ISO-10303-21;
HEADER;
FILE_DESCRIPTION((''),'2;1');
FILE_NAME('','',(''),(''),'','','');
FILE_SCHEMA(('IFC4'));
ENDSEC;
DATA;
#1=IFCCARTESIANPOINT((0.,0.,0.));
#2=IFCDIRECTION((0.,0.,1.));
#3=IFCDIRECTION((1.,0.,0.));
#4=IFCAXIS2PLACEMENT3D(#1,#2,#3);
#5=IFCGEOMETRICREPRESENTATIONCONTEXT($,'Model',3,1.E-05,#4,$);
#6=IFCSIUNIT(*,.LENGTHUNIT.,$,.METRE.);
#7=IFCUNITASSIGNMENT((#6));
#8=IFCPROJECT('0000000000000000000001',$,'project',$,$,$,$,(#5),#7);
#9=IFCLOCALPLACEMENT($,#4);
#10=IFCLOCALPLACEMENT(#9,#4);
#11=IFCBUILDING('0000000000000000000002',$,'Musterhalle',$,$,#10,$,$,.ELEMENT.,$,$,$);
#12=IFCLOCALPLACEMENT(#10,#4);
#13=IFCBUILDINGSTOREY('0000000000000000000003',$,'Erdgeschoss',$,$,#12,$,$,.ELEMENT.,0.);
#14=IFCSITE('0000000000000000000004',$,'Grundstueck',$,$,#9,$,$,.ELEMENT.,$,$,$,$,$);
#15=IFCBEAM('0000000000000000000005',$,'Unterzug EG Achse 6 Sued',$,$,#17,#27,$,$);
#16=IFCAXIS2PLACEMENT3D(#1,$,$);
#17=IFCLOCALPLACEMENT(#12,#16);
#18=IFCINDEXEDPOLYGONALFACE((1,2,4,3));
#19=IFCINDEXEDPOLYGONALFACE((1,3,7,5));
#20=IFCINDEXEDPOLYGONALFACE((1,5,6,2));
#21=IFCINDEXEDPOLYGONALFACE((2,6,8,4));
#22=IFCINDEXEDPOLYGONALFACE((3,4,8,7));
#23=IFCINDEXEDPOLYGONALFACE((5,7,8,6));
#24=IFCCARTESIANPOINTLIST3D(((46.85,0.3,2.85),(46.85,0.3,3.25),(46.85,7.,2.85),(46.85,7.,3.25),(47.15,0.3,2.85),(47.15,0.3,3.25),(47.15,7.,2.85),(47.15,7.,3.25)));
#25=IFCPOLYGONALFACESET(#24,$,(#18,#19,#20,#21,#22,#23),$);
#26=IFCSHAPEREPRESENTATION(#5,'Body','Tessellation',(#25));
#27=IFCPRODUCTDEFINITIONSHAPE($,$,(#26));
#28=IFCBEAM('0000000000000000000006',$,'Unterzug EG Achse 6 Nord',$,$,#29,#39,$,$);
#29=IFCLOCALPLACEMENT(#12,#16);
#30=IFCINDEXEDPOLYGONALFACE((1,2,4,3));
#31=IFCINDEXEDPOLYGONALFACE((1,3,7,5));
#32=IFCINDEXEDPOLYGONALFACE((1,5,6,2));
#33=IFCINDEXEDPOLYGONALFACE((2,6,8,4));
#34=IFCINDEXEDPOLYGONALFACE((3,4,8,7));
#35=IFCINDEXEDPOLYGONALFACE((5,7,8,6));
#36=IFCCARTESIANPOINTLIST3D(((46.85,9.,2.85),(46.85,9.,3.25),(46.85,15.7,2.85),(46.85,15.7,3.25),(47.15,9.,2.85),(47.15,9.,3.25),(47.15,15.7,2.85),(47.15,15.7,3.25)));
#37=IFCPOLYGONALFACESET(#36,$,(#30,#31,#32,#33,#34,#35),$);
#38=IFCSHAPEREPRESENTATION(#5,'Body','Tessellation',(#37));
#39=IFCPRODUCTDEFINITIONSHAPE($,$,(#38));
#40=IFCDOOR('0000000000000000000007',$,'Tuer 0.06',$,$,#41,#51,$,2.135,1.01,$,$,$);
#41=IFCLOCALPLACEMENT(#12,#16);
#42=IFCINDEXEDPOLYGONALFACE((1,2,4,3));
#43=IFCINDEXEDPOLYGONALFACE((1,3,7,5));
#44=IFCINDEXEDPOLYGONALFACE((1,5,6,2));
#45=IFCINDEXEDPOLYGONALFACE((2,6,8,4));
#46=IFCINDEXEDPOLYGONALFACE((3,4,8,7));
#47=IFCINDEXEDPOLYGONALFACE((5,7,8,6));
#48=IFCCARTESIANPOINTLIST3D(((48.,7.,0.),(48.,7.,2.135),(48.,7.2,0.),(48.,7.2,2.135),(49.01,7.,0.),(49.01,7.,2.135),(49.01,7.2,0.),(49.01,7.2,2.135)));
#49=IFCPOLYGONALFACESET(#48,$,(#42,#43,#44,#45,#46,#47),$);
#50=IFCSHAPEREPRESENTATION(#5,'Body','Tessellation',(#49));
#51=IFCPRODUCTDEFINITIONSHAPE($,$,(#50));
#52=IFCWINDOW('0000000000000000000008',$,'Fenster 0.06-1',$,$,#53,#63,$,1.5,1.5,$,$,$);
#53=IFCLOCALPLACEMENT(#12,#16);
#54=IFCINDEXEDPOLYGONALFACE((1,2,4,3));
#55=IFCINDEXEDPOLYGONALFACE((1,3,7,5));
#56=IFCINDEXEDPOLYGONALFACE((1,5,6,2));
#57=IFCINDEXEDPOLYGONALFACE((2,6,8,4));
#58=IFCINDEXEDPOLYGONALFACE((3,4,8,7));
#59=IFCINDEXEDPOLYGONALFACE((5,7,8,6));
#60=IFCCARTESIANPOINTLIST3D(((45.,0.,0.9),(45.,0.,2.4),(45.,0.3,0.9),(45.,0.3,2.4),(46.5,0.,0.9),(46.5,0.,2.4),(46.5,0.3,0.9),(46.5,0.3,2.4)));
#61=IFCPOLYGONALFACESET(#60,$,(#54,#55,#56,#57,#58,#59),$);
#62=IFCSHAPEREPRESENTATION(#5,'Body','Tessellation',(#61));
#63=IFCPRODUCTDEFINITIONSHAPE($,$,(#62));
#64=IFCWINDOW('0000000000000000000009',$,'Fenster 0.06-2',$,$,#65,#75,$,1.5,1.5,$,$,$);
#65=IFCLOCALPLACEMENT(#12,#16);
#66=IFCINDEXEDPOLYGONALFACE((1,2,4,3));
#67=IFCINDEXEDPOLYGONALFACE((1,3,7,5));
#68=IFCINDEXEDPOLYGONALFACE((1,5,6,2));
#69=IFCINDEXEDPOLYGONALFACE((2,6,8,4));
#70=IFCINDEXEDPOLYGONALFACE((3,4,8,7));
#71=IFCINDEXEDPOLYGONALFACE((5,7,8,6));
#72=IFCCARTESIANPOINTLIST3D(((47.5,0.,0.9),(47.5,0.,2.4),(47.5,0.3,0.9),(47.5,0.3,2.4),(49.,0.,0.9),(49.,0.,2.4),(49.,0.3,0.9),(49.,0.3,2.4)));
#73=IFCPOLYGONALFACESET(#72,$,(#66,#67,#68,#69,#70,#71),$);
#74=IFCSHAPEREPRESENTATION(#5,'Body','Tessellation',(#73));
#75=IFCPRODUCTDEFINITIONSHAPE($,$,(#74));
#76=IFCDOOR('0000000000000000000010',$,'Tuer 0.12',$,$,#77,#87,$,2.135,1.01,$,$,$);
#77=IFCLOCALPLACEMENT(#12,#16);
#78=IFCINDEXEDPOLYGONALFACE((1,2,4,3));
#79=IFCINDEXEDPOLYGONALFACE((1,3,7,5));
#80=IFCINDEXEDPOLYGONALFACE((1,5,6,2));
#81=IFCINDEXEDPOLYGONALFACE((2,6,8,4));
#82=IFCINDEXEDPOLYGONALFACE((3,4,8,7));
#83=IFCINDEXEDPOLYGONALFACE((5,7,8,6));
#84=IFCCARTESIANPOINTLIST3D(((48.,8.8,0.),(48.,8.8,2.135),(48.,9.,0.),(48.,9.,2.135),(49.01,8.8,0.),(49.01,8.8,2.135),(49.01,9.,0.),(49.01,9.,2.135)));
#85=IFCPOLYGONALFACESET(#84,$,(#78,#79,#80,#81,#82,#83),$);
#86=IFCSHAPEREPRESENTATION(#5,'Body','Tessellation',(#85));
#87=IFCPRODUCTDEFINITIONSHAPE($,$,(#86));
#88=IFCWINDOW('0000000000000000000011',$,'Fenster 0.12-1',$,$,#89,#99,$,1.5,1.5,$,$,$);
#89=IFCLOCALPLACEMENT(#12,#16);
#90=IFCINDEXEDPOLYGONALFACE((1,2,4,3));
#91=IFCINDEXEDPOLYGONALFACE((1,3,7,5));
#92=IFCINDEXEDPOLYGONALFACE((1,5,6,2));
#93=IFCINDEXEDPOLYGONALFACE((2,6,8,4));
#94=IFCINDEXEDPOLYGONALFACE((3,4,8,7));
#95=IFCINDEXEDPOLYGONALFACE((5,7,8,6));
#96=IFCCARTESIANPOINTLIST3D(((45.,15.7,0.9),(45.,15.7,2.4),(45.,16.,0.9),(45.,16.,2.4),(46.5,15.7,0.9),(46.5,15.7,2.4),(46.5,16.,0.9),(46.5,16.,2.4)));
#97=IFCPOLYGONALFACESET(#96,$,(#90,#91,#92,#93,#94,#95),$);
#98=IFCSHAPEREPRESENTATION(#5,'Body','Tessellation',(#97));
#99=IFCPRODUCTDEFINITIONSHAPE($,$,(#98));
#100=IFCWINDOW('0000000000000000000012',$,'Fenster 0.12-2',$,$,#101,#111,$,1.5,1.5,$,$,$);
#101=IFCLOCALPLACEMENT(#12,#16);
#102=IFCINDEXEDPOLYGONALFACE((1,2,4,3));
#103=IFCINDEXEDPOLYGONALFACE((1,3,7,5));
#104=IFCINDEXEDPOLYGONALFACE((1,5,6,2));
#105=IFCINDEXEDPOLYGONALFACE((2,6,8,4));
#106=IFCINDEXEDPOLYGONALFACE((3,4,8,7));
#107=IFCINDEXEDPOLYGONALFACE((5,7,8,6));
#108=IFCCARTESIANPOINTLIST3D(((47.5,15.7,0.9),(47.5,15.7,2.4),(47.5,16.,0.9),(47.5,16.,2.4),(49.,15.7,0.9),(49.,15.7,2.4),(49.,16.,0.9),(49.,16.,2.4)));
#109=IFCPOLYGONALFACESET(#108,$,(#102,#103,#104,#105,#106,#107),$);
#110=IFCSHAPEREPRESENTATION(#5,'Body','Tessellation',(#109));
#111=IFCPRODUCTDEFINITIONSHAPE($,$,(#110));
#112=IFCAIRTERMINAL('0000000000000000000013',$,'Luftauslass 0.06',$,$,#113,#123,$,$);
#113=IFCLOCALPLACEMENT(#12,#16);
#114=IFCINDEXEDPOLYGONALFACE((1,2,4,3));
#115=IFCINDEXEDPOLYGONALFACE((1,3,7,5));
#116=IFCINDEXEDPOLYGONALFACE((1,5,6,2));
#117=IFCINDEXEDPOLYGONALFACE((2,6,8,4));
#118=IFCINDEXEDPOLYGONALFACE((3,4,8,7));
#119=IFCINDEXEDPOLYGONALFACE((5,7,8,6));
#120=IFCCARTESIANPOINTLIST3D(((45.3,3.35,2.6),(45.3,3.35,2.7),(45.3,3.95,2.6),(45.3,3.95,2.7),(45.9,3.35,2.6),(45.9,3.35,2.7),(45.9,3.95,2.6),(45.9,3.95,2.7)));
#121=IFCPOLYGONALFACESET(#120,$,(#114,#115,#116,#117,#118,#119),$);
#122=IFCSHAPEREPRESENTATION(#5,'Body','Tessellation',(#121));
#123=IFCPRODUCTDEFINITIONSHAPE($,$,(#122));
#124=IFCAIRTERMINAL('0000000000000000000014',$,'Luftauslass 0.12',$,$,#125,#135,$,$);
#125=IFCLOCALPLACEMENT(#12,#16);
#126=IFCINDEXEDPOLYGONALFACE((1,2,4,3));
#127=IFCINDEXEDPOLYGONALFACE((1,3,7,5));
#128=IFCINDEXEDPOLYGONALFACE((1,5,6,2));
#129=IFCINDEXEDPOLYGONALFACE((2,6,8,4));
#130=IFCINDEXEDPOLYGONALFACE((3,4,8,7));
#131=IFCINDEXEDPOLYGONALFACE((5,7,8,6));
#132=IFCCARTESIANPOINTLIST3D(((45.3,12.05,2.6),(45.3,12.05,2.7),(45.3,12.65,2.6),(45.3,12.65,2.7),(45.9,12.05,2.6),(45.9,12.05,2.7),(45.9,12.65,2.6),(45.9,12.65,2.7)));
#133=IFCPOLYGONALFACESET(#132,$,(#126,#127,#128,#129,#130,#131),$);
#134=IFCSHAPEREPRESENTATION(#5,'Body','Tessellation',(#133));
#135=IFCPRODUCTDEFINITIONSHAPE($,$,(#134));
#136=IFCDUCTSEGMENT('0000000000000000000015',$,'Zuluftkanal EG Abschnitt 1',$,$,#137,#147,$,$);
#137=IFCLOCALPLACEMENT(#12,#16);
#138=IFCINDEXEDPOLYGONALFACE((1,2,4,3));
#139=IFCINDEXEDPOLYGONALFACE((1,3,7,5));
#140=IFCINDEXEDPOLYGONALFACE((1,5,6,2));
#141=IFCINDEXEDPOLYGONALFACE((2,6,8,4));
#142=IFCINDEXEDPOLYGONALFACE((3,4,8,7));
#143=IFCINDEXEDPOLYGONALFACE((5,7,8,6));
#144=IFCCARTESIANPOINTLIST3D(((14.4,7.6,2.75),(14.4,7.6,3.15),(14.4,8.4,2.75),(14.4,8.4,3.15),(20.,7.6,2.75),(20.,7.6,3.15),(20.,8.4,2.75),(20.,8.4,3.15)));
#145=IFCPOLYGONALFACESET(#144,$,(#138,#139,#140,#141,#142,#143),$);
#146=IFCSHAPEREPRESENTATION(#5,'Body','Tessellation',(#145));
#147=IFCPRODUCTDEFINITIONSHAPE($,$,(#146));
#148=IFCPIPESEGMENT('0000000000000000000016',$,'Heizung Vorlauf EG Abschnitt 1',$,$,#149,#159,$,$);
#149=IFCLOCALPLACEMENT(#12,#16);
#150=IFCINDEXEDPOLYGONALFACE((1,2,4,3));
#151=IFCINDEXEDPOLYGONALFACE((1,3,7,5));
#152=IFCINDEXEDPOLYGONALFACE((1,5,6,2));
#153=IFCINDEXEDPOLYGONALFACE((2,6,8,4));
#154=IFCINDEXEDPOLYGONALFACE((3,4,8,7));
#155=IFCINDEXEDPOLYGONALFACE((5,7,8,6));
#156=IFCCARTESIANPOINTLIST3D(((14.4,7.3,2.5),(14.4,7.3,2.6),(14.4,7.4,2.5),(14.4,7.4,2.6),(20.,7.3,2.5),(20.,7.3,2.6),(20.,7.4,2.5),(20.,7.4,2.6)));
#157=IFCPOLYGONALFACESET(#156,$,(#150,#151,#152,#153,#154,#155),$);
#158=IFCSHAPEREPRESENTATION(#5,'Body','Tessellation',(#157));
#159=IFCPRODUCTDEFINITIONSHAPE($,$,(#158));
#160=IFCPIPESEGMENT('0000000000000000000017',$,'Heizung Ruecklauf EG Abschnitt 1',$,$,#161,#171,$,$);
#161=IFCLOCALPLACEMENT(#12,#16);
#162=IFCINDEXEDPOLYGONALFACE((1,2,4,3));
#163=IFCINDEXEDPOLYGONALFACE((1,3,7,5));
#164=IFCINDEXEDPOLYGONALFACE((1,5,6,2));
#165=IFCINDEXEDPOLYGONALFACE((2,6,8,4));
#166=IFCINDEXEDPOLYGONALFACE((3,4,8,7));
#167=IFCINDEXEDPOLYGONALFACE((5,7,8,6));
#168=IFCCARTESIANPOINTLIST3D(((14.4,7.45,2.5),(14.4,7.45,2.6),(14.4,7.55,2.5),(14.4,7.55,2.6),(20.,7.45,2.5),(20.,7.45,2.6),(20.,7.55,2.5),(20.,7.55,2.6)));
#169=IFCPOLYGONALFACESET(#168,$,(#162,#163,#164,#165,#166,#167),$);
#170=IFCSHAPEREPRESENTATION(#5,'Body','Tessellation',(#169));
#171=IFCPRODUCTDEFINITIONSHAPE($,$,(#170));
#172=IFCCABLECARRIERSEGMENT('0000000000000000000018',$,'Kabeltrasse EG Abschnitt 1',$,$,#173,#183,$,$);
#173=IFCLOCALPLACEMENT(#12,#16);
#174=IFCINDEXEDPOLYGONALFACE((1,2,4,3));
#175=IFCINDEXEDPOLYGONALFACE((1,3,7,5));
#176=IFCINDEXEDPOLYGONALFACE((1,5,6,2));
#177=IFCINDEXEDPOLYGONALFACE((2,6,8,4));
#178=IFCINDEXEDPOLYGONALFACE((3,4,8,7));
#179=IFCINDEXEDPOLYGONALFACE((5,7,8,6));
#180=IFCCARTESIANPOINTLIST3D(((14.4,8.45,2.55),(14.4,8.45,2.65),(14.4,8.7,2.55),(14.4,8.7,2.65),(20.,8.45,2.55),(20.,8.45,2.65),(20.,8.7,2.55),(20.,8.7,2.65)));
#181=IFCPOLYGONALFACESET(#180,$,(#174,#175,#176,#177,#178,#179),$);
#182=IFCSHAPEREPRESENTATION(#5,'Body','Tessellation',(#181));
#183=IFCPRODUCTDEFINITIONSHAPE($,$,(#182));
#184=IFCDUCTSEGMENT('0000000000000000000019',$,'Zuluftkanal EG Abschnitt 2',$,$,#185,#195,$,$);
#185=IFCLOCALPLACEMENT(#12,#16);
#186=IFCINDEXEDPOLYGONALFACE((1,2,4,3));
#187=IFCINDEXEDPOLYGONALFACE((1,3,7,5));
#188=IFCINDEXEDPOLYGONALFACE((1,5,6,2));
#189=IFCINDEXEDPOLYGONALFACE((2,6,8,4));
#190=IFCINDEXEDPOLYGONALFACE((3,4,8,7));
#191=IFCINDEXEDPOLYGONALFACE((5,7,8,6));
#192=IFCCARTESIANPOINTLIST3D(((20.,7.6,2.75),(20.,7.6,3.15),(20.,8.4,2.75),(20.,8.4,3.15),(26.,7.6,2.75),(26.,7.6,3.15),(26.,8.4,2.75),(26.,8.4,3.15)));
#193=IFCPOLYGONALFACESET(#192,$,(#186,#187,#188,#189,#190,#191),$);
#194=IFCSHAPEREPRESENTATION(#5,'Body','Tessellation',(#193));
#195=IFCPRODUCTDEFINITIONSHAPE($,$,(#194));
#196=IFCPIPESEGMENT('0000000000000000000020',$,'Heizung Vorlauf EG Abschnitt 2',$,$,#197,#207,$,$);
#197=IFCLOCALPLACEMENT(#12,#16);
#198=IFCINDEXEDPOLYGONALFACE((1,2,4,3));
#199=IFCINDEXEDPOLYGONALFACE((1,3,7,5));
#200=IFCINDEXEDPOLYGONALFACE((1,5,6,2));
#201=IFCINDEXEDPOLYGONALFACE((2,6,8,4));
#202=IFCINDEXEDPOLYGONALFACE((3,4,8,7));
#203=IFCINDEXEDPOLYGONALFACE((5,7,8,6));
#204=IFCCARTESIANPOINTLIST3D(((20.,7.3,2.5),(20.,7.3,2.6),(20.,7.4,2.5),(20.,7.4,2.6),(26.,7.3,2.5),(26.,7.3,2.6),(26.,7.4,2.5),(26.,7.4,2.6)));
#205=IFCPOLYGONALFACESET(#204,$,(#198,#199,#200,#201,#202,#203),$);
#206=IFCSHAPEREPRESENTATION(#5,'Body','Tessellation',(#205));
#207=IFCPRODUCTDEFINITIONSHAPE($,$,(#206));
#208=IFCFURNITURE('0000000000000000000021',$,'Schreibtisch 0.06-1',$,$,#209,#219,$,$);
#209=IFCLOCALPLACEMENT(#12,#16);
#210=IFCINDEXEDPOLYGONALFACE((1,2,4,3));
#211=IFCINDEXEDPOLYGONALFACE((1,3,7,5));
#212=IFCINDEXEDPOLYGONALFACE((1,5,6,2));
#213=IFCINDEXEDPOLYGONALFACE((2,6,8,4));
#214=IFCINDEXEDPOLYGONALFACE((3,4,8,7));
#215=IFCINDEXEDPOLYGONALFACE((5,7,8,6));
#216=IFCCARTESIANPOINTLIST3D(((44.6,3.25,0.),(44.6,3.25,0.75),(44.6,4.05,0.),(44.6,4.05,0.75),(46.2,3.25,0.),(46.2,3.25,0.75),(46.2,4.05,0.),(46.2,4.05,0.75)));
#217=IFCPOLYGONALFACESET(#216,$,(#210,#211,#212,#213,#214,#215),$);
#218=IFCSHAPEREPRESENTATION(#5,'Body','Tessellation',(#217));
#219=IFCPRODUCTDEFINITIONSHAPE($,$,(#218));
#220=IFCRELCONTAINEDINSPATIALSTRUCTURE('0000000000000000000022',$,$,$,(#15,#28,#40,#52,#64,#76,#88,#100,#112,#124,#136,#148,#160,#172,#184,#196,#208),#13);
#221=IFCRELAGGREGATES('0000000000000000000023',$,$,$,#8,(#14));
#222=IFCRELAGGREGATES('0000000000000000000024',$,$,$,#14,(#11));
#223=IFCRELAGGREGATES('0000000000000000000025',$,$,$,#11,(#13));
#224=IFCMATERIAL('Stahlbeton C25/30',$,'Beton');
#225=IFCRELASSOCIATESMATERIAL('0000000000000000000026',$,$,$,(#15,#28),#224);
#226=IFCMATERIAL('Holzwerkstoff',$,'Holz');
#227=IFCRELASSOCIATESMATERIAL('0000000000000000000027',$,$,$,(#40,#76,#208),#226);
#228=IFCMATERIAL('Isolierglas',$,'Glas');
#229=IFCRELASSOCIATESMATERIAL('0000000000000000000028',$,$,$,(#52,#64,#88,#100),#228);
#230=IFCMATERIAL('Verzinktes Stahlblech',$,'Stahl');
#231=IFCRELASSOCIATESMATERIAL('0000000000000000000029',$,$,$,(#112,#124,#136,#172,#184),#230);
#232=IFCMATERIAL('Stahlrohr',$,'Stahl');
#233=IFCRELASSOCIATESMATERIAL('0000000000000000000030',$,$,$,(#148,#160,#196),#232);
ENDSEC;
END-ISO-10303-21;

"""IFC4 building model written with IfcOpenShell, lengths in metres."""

from ifc_helpers import new_model, si_unit, frame, origin_with_axes, origin_2d, place, context, project, spatial, rectangle, extrude, material, element, save


model = new_model("IFC4")

# Units and contexts
model_context = context("Model", 3, precision=1e-05, world=origin_with_axes())
ifc_project = project(units=[si_unit("LENGTHUNIT", "METRE")], contexts=[model_context])

# Site, building, storey
site_placement = place(None, origin_with_axes())
site = spatial("IfcSite", under=ifc_project, at=site_placement, Name="Grundstueck", CompositionType="ELEMENT")
building_placement = place(site_placement, origin_with_axes())
building = spatial("IfcBuilding", under=site, at=building_placement, Name="Musterhalle", CompositionType="ELEMENT")
storey_placement = place(building_placement, origin_with_axes())
storey = spatial("IfcBuildingStorey", under=building, at=storey_placement, Name="Erdgeschoss", CompositionType="ELEMENT", Elevation=0.0)

# Beams
ifc_material_1 = material(Name="Stahlbeton C25/30", Category="Beton")
placement = place(storey_placement, origin_with_axes())
element("IfcBeam", 1, at=placement, inside=storey, material=ifc_material_1, Name="Unterzug EG Achse 6 Sued", context=model_context, shape_type="SweptSolid", body=[
    extrude(rectangle(XDim=0.3, YDim=6.7, at=origin_2d()), frame((47.0, 3.65, 2.85), z_axis=(0.0, 0.0, 1.0), x_axis=(1.0, 0.0, 0.0)), (0.0, 0.0, 1.0), 0.4),
])
element("IfcBeam", 2, at=placement, inside=storey, material=ifc_material_1, Name="Unterzug EG Achse 6 Nord", context=model_context, shape_type="SweptSolid", body=[
    extrude(rectangle(XDim=0.3, YDim=6.7, at=origin_2d()), frame((47.0, 12.35, 2.85), z_axis=(0.0, 0.0, 1.0), x_axis=(1.0, 0.0, 0.0)), (0.0, 0.0, 1.0), 0.4),
])

# Door
ifc_material_2 = material(Name="Holzwerkstoff", Category="Holz")
element("IfcDoor", 3, at=placement, inside=storey, material=ifc_material_2, Name="Tuer 0.06", OverallHeight=2.135, OverallWidth=1.01, context=model_context, shape_type="SweptSolid", body=[
    extrude(rectangle(XDim=1.01, YDim=0.2, at=origin_2d()), frame((48.505, 7.1, 0.0), z_axis=(0.0, 0.0, 1.0), x_axis=(1.0, 0.0, 0.0)), (0.0, 0.0, 1.0), 2.135),
])

# Windows
ifc_material_3 = material(Name="Isolierglas", Category="Glas")
element("IfcWindow", 4, at=placement, inside=storey, material=ifc_material_3, Name="Fenster 0.06-1", OverallHeight=1.5, OverallWidth=1.5, context=model_context, shape_type="SweptSolid", body=[
    extrude(rectangle(XDim=1.5, YDim=0.3, at=origin_2d()), frame((45.75, 0.15, 0.9), z_axis=(0.0, 0.0, 1.0), x_axis=(1.0, 0.0, 0.0)), (0.0, 0.0, 1.0), 1.5),
])
element("IfcWindow", 5, at=placement, inside=storey, material=ifc_material_3, Name="Fenster 0.06-2", OverallHeight=1.5, OverallWidth=1.5, context=model_context, shape_type="SweptSolid", body=[
    extrude(rectangle(XDim=1.5, YDim=0.3, at=origin_2d()), frame((48.25, 0.15, 0.9), z_axis=(0.0, 0.0, 1.0), x_axis=(1.0, 0.0, 0.0)), (0.0, 0.0, 1.0), 1.5),
])

# Door
element("IfcDoor", 6, at=placement, inside=storey, material=ifc_material_2, Name="Tuer 0.12", OverallHeight=2.135, OverallWidth=1.01, context=model_context, shape_type="SweptSolid", body=[
    extrude(rectangle(XDim=1.01, YDim=0.2, at=origin_2d()), frame((48.505, 8.9, 0.0), z_axis=(0.0, 0.0, 1.0), x_axis=(1.0, 0.0, 0.0)), (0.0, 0.0, 1.0), 2.135),
])

# Windows
element("IfcWindow", 7, at=placement, inside=storey, material=ifc_material_3, Name="Fenster 0.12-1", OverallHeight=1.5, OverallWidth=1.5, context=model_context, shape_type="SweptSolid", body=[
    extrude(rectangle(XDim=1.5, YDim=0.3, at=origin_2d()), frame((45.75, 15.85, 0.9), z_axis=(0.0, 0.0, 1.0), x_axis=(1.0, 0.0, 0.0)), (0.0, 0.0, 1.0), 1.5),
])
element("IfcWindow", 8, at=placement, inside=storey, material=ifc_material_3, Name="Fenster 0.12-2", OverallHeight=1.5, OverallWidth=1.5, context=model_context, shape_type="SweptSolid", body=[
    extrude(rectangle(XDim=1.5, YDim=0.3, at=origin_2d()), frame((48.25, 15.85, 0.9), z_axis=(0.0, 0.0, 1.0), x_axis=(1.0, 0.0, 0.0)), (0.0, 0.0, 1.0), 1.5),
])

# Air terminals
ifc_material_4 = material(Name="Verzinktes Stahlblech", Category="Stahl")
element("IfcAirTerminal", 9, at=placement, inside=storey, material=ifc_material_4, Name="Luftauslass 0.06", context=model_context, shape_type="SweptSolid", body=[
    extrude(rectangle(XDim=0.6, YDim=0.6, at=origin_2d()), frame((45.6, 3.65, 2.6), z_axis=(0.0, 0.0, 1.0), x_axis=(1.0, 0.0, 0.0)), (0.0, 0.0, 1.0), 0.1),
])
element("IfcAirTerminal", 10, at=placement, inside=storey, material=ifc_material_4, Name="Luftauslass 0.12", context=model_context, shape_type="SweptSolid", body=[
    extrude(rectangle(XDim=0.6, YDim=0.6, at=origin_2d()), frame((45.6, 12.35, 2.6), z_axis=(0.0, 0.0, 1.0), x_axis=(1.0, 0.0, 0.0)), (0.0, 0.0, 1.0), 0.1),
])

# Duct segment
element("IfcDuctSegment", 11, at=placement, inside=storey, material=ifc_material_4, Name="Zuluftkanal EG Abschnitt 1", context=model_context, shape_type="SweptSolid", body=[
    extrude(rectangle(XDim=5.6, YDim=0.8, at=origin_2d()), frame((17.2, 8.0, 2.75), z_axis=(0.0, 0.0, 1.0), x_axis=(1.0, 0.0, 0.0)), (0.0, 0.0, 1.0), 0.4),
])

# Pipe segments
ifc_material_5 = material(Name="Stahlrohr", Category="Stahl")
element("IfcPipeSegment", 12, at=placement, inside=storey, material=ifc_material_5, Name="Heizung Vorlauf EG Abschnitt 1", context=model_context, shape_type="SweptSolid", body=[
    extrude(rectangle(XDim=5.6, YDim=0.1, at=origin_2d()), frame((17.2, 7.35, 2.5), z_axis=(0.0, 0.0, 1.0), x_axis=(1.0, 0.0, 0.0)), (0.0, 0.0, 1.0), 0.1),
])
element("IfcPipeSegment", 13, at=placement, inside=storey, material=ifc_material_5, Name="Heizung Ruecklauf EG Abschnitt 1", context=model_context, shape_type="SweptSolid", body=[
    extrude(rectangle(XDim=5.6, YDim=0.1, at=origin_2d()), frame((17.2, 7.5, 2.5), z_axis=(0.0, 0.0, 1.0), x_axis=(1.0, 0.0, 0.0)), (0.0, 0.0, 1.0), 0.1),
])

# Cable carrier segment
element("IfcCableCarrierSegment", 14, at=placement, inside=storey, material=ifc_material_4, Name="Kabeltrasse EG Abschnitt 1", context=model_context, shape_type="SweptSolid", body=[
    extrude(rectangle(XDim=5.6, YDim=0.25, at=origin_2d()), frame((17.2, 8.575, 2.55), z_axis=(0.0, 0.0, 1.0), x_axis=(1.0, 0.0, 0.0)), (0.0, 0.0, 1.0), 0.1),
])

# Duct segment
element("IfcDuctSegment", 15, at=placement, inside=storey, material=ifc_material_4, Name="Zuluftkanal EG Abschnitt 2", context=model_context, shape_type="SweptSolid", body=[
    extrude(rectangle(XDim=6.0, YDim=0.8, at=origin_2d()), frame((23.0, 8.0, 2.75), z_axis=(0.0, 0.0, 1.0), x_axis=(1.0, 0.0, 0.0)), (0.0, 0.0, 1.0), 0.4),
])

# Pipe segment
element("IfcPipeSegment", 16, at=placement, inside=storey, material=ifc_material_5, Name="Heizung Vorlauf EG Abschnitt 2", context=model_context, shape_type="SweptSolid", body=[
    extrude(rectangle(XDim=6.0, YDim=0.1, at=origin_2d()), frame((23.0, 7.35, 2.5), z_axis=(0.0, 0.0, 1.0), x_axis=(1.0, 0.0, 0.0)), (0.0, 0.0, 1.0), 0.1),
])

# Furniture
element("IfcFurniture", 17, at=placement, inside=storey, material=ifc_material_2, Name="Schreibtisch 0.06-1", context=model_context, shape_type="SweptSolid", body=[
    extrude(rectangle(XDim=1.6, YDim=0.8, at=origin_2d()), frame((45.4, 3.65, 0.0), z_axis=(0.0, 0.0, 1.0), x_axis=(1.0, 0.0, 0.0)), (0.0, 0.0, 1.0), 0.75),
])

save(model, "model.ifc")
